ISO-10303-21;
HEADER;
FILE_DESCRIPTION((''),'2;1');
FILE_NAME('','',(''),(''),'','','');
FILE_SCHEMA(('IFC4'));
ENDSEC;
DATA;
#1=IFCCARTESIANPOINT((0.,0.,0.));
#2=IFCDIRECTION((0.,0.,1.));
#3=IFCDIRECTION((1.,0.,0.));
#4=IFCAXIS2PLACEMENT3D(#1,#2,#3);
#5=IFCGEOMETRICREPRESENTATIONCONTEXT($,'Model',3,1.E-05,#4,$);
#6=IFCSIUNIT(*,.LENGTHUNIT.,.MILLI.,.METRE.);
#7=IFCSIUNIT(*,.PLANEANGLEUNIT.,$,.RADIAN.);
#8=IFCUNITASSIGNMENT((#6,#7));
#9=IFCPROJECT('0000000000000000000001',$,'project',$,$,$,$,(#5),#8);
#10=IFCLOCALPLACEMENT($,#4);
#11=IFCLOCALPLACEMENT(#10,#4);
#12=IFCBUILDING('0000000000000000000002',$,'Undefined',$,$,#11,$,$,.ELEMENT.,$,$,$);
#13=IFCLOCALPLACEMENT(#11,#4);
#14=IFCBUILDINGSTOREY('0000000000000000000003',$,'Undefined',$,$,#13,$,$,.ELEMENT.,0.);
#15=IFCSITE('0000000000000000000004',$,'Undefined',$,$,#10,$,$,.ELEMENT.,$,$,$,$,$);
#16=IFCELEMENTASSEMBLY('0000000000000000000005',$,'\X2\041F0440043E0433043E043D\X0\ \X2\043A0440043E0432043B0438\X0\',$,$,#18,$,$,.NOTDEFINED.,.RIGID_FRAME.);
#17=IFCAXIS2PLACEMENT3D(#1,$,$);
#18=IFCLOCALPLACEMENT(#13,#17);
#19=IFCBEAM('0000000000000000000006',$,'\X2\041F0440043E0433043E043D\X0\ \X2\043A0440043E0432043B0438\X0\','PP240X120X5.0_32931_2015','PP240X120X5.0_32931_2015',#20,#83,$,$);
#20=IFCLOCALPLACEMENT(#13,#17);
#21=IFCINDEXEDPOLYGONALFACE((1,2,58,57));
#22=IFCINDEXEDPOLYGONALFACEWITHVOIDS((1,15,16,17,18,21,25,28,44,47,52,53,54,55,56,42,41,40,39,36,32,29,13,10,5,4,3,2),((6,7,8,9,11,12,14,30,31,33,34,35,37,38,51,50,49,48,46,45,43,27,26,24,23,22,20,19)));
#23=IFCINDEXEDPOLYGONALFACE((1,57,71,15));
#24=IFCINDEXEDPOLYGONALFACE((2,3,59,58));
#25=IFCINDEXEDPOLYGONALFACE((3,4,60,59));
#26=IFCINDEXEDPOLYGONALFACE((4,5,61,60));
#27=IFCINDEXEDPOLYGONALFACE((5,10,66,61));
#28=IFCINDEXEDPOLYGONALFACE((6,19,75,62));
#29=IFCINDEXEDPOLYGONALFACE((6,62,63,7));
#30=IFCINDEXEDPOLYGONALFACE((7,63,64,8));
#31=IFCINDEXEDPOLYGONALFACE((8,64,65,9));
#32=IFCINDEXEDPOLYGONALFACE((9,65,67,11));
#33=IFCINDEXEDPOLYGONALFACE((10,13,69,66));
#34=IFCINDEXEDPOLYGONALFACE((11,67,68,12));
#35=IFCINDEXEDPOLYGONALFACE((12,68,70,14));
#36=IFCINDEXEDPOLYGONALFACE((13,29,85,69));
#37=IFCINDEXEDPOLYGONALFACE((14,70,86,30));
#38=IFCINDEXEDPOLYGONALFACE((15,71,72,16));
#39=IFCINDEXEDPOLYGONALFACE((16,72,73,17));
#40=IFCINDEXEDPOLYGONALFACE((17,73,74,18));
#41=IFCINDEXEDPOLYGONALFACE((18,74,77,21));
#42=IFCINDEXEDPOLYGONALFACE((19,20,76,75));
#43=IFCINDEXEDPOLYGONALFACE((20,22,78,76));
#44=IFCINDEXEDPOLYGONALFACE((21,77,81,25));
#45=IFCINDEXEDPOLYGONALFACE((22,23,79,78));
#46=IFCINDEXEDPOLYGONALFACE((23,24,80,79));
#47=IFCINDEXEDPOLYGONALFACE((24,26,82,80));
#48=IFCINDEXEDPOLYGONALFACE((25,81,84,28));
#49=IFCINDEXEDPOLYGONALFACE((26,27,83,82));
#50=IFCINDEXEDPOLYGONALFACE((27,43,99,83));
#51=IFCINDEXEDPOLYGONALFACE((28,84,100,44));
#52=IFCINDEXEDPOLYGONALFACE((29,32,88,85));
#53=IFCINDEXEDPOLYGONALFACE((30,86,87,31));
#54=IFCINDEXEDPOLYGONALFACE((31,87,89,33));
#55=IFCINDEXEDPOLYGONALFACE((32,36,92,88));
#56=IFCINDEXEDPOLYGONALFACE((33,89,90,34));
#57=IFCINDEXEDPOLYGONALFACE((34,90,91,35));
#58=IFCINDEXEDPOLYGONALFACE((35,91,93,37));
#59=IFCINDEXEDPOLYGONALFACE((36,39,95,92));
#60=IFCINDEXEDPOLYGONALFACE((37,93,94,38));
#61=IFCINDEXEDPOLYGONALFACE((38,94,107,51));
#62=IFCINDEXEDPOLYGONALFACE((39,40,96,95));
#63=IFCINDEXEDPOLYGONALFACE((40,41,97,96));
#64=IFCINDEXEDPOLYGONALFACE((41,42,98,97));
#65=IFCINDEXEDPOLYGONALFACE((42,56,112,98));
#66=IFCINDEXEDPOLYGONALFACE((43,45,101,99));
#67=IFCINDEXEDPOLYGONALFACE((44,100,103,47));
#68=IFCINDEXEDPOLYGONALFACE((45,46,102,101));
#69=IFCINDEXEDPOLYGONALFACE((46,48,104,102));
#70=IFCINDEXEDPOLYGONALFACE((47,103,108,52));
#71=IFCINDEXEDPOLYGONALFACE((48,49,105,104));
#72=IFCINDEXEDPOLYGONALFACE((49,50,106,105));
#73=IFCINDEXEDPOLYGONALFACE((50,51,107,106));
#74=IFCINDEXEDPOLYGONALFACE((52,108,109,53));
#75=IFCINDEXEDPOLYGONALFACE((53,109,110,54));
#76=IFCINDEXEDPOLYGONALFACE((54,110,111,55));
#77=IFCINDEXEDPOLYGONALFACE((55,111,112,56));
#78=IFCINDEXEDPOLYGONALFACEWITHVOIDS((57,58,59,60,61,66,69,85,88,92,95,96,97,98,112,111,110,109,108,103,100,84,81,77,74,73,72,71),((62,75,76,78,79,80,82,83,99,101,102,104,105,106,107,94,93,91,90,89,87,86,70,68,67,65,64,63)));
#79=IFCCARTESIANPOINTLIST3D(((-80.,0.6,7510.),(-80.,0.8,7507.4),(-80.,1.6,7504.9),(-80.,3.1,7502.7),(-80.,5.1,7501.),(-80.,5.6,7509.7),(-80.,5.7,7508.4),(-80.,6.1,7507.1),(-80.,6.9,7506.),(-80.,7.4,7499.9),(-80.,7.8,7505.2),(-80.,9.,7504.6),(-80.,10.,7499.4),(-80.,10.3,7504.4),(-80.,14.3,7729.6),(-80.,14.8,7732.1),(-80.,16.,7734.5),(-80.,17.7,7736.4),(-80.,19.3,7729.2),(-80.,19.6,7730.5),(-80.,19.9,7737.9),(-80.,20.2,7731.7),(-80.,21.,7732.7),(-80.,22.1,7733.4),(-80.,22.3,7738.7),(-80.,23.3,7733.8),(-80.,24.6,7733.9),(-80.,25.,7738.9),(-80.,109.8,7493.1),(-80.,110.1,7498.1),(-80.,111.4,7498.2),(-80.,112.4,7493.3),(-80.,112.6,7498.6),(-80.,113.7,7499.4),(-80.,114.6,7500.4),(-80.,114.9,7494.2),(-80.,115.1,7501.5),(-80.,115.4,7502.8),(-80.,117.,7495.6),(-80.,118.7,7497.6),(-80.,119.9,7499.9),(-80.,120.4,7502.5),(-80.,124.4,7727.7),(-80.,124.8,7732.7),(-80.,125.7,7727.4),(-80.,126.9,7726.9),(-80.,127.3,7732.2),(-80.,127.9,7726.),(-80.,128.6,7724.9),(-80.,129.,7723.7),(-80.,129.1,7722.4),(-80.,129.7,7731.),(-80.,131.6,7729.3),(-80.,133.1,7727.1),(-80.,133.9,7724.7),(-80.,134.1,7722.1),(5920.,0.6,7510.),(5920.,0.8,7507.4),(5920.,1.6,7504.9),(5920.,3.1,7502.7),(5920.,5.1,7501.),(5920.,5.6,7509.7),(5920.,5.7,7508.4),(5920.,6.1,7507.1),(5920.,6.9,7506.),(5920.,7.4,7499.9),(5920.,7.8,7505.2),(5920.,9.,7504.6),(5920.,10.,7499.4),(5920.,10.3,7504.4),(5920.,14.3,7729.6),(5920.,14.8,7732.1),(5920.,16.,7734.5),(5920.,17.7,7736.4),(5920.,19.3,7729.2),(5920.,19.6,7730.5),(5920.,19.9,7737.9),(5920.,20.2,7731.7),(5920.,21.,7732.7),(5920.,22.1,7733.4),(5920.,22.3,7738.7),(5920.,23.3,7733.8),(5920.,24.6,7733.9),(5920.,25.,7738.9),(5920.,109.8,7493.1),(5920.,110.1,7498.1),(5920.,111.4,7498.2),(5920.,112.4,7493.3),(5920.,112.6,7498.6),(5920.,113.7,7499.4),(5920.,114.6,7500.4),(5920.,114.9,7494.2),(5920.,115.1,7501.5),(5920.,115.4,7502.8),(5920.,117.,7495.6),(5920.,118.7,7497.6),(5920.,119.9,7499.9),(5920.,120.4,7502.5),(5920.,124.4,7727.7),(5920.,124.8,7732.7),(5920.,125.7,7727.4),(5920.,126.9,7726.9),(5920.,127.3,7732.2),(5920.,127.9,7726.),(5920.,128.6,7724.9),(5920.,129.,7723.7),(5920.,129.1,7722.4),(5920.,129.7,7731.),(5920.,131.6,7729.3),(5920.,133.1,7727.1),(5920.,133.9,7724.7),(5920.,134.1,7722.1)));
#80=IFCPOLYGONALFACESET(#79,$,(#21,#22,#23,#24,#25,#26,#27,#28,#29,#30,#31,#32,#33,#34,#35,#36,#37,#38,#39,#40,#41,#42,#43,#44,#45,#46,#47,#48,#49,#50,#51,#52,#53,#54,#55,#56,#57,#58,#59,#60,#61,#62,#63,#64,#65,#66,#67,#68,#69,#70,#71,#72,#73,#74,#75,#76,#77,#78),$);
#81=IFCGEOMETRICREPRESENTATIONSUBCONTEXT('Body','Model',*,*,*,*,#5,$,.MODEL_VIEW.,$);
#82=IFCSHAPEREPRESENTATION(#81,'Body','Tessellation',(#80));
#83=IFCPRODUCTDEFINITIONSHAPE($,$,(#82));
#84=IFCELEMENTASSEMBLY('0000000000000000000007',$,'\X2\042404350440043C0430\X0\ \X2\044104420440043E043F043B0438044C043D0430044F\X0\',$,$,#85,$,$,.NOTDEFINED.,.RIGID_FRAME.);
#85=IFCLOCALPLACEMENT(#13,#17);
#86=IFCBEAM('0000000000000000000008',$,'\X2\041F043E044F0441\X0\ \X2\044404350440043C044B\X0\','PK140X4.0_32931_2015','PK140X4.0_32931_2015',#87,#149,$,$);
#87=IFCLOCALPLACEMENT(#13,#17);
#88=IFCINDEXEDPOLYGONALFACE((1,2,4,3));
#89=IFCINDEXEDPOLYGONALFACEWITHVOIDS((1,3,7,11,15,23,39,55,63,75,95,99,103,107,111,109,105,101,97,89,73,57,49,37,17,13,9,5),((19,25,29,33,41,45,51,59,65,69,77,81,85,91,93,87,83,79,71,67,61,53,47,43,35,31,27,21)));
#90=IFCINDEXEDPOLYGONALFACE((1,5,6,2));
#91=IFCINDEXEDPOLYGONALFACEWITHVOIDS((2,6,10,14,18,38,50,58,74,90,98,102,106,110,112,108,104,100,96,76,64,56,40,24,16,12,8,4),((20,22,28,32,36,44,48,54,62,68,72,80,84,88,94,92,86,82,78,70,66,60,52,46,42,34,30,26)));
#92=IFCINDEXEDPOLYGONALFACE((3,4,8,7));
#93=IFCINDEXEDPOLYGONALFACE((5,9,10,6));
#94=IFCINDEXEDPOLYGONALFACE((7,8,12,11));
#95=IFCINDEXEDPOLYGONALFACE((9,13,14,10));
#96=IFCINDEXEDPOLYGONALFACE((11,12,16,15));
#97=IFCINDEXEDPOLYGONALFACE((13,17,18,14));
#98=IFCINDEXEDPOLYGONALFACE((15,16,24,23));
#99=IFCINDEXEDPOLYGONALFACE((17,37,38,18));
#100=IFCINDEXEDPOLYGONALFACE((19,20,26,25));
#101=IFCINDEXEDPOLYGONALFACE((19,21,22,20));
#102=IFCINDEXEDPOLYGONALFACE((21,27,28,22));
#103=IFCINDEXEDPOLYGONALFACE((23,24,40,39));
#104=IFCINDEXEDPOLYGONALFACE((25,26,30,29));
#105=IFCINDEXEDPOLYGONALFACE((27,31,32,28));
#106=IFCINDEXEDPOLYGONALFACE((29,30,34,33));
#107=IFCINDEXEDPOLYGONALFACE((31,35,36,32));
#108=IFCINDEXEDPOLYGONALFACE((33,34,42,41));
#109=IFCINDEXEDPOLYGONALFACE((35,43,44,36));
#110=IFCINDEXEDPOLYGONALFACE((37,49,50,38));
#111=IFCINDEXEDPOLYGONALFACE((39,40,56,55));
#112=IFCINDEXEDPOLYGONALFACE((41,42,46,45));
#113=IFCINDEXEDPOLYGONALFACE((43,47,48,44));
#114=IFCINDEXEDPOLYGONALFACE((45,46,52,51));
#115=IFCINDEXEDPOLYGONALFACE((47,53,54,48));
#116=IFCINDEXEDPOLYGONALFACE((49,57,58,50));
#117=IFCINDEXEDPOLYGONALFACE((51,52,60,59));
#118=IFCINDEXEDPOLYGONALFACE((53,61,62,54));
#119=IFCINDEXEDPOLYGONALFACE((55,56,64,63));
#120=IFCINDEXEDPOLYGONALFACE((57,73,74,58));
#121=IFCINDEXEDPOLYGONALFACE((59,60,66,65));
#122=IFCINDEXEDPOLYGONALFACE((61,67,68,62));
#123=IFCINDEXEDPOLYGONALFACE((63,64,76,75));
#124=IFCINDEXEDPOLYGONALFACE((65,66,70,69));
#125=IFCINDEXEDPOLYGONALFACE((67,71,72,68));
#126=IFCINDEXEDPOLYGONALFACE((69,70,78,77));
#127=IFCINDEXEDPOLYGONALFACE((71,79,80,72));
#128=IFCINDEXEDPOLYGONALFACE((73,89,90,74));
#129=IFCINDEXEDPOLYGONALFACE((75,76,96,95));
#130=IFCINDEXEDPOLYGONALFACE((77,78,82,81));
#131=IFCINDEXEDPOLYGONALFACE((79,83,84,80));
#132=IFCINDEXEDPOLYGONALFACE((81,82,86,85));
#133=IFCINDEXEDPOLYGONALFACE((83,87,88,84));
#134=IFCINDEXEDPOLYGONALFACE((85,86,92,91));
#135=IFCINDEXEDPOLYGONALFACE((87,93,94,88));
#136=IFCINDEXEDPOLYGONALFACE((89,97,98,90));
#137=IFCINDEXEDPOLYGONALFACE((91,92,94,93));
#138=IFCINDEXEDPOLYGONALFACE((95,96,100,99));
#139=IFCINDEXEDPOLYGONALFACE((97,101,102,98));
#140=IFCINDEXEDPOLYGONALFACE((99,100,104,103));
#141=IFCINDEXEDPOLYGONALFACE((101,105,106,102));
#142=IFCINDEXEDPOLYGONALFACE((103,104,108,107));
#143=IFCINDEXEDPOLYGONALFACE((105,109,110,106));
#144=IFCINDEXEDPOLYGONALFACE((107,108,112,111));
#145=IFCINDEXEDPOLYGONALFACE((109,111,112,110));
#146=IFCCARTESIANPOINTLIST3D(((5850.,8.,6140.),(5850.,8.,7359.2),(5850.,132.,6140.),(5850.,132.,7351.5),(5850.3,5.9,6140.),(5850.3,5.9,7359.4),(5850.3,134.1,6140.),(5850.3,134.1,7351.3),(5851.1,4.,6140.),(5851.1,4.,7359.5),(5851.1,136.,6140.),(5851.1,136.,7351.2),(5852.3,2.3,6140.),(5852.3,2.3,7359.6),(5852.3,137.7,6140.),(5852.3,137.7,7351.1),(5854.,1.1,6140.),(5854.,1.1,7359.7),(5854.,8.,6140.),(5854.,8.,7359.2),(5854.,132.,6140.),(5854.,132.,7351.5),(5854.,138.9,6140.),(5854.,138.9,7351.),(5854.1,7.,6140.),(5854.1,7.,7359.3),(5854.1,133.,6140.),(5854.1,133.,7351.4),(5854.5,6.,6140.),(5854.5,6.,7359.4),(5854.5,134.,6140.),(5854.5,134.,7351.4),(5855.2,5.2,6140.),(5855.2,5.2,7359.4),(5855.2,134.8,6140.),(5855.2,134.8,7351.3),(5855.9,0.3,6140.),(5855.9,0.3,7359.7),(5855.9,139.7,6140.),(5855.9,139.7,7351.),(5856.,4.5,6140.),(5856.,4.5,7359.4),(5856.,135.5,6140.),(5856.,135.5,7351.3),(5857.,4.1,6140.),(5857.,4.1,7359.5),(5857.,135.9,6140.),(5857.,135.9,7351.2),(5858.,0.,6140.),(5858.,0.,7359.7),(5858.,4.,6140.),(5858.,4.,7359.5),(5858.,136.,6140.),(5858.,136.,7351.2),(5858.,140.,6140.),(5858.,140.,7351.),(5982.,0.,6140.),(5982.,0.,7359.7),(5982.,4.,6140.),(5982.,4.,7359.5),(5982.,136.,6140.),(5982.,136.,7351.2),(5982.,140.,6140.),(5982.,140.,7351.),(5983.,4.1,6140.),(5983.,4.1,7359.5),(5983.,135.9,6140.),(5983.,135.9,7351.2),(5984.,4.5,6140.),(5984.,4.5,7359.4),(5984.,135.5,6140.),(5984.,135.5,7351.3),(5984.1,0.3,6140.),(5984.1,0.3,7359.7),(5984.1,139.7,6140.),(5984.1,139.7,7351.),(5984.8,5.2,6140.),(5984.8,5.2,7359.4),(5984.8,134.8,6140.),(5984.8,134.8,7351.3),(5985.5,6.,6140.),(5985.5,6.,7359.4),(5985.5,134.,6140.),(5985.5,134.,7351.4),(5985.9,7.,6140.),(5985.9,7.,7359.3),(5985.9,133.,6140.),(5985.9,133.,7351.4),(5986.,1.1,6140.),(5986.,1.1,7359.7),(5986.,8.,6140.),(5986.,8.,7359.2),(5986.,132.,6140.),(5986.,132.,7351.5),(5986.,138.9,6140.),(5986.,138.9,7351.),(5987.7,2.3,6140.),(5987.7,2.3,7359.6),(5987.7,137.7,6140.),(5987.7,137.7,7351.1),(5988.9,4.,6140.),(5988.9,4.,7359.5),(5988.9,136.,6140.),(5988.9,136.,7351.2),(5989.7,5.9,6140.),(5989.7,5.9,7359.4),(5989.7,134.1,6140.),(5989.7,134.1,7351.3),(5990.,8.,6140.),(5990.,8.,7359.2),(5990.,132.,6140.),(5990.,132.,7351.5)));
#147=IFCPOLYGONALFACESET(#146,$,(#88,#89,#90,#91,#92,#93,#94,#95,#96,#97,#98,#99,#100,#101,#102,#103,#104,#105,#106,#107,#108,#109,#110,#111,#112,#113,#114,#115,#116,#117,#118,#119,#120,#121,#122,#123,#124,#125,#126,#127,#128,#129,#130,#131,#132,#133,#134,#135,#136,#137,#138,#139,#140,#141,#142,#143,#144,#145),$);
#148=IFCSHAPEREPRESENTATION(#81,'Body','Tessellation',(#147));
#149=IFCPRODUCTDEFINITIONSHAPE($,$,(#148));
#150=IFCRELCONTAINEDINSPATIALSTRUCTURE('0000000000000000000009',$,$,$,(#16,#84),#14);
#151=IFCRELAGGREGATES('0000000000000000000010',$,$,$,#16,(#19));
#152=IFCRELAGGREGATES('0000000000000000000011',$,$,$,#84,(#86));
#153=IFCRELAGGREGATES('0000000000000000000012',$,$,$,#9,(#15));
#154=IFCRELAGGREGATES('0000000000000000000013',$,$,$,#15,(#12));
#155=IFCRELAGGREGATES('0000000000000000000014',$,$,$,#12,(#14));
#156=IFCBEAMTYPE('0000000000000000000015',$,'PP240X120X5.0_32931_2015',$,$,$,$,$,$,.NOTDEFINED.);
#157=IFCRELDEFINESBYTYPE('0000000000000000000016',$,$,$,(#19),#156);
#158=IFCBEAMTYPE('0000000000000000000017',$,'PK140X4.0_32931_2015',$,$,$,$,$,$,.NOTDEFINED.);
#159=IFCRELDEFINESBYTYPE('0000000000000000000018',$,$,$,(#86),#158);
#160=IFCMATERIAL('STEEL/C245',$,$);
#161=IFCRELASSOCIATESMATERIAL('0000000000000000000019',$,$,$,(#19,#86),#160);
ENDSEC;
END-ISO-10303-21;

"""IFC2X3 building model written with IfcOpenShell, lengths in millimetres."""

from ifc_helpers import new_model, si_unit, frame, origin_with_axes, origin_2d_with_axis, place, context, subcontext, project, spatial, hollow_rectangle, extrude, clip, halfspace, material, type_object, element, aggregate, save


model = new_model("IFC2X3")

# Units and contexts
model_context = context("Model", 3, precision=1e-05, world=origin_with_axes())
body_context = subcontext(model_context, "Body", "Model", "MODEL_VIEW")
ifc_project = project(units=[si_unit("LENGTHUNIT", "METRE", prefix="MILLI"), si_unit("PLANEANGLEUNIT", "RADIAN")], contexts=[model_context])

# Site, building, storey
site_placement = place(None, origin_with_axes())
site = spatial("IfcSite", under=ifc_project, at=site_placement, Name="Undefined", CompositionType="ELEMENT")
building_placement = place(site_placement, origin_with_axes())
building = spatial("IfcBuilding", under=site, at=building_placement, Name="Undefined", CompositionType="ELEMENT")
storey_placement = place(building_placement, origin_with_axes())
storey = spatial("IfcBuildingStorey", under=building, at=storey_placement, Name="Undefined", CompositionType="ELEMENT", Elevation=0.0)

# Shared definitions
ifc_material = material(Name="STEEL/C245")

# Element assembly, beam
beam_type_1 = type_object("IfcBeamType", Name="PP240X120X5.0_32931_2015", PredefinedType="NOTDEFINED")
assembly_1_placement = place(storey_placement, origin_with_axes())
assembly_1 = element("IfcElementAssembly", 1, at=assembly_1_placement, inside=storey, Name="Прогон кровли", AssemblyPlace="NOTDEFINED", PredefinedType="RIGID_FRAME")
beam_1_placement = place(assembly_1_placement, frame((5920.0, 67.4, 7616.0), z_axis=(0.0, 0.062378, 0.998053), x_axis=(-1.0, 0.0, 0.0)))
beam_1 = element("IfcBeam", 2, at=beam_1_placement, type_object=beam_type_1, material=ifc_material, Name="Прогон кровли", Description="PP240X120X5.0_32931_2015", ObjectType="PP240X120X5.0_32931_2015", context=body_context, shape_type="SweptSolid", body=[
    extrude(hollow_rectangle(XDim=120.0, YDim=240.0, WallThickness=5.0, InnerFilletRadius=5.0, OuterFilletRadius=10.0, at=origin_2d_with_axis()), frame((6000.0, 0.0, 0.0), z_axis=(-1.0, 0.0, 0.0), x_axis=(0.0, -1.0, 0.0)), (0.0, 0.0, 1.0), 6000.0),
])
aggregate(assembly_1, [beam_1])

# Element assembly
assembly_2_placement = place(storey_placement, origin_with_axes())
assembly_2 = element("IfcElementAssembly", 3, at=assembly_2_placement, inside=storey, Name="Ферма строплиьная", AssemblyPlace="NOTDEFINED", PredefinedType="RIGID_FRAME")

# Beam
beam_type_2 = type_object("IfcBeamType", Name="PK140X4.0_32931_2015", PredefinedType="NOTDEFINED")
beam_2_placement = place(assembly_2_placement, frame((5920.0, 70.0, 7359.7), z_axis=(1.0, 0.0, 0.0), x_axis=(0.0, 0.0, -1.0)))
beam_2 = element("IfcBeam", 4, at=beam_2_placement, type_object=beam_type_2, material=ifc_material, Name="Пояс фермы", Description="PK140X4.0_32931_2015", ObjectType="PK140X4.0_32931_2015", context=body_context, shape_type="Clipping", body=[
    clip(extrude(hollow_rectangle(XDim=140.0, YDim=140.0, WallThickness=4.0, InnerFilletRadius=4.0, OuterFilletRadius=8.0, at=origin_2d_with_axis()), frame((1219.7, 0.0, 0.0), z_axis=(-1.0, 0.0, 0.0), x_axis=(0.0, -1.0, 0.0)), (0.0, 0.0, 1.0), 1219.8), halfspace(frame((10.5, 98.4, 0.0), z_axis=(0.998053, -0.062378, 0.0), x_axis=(0.0, 0.0, 1.0)), True)),
])
aggregate(assembly_2, [beam_2])

save(model, "model.ifc")
